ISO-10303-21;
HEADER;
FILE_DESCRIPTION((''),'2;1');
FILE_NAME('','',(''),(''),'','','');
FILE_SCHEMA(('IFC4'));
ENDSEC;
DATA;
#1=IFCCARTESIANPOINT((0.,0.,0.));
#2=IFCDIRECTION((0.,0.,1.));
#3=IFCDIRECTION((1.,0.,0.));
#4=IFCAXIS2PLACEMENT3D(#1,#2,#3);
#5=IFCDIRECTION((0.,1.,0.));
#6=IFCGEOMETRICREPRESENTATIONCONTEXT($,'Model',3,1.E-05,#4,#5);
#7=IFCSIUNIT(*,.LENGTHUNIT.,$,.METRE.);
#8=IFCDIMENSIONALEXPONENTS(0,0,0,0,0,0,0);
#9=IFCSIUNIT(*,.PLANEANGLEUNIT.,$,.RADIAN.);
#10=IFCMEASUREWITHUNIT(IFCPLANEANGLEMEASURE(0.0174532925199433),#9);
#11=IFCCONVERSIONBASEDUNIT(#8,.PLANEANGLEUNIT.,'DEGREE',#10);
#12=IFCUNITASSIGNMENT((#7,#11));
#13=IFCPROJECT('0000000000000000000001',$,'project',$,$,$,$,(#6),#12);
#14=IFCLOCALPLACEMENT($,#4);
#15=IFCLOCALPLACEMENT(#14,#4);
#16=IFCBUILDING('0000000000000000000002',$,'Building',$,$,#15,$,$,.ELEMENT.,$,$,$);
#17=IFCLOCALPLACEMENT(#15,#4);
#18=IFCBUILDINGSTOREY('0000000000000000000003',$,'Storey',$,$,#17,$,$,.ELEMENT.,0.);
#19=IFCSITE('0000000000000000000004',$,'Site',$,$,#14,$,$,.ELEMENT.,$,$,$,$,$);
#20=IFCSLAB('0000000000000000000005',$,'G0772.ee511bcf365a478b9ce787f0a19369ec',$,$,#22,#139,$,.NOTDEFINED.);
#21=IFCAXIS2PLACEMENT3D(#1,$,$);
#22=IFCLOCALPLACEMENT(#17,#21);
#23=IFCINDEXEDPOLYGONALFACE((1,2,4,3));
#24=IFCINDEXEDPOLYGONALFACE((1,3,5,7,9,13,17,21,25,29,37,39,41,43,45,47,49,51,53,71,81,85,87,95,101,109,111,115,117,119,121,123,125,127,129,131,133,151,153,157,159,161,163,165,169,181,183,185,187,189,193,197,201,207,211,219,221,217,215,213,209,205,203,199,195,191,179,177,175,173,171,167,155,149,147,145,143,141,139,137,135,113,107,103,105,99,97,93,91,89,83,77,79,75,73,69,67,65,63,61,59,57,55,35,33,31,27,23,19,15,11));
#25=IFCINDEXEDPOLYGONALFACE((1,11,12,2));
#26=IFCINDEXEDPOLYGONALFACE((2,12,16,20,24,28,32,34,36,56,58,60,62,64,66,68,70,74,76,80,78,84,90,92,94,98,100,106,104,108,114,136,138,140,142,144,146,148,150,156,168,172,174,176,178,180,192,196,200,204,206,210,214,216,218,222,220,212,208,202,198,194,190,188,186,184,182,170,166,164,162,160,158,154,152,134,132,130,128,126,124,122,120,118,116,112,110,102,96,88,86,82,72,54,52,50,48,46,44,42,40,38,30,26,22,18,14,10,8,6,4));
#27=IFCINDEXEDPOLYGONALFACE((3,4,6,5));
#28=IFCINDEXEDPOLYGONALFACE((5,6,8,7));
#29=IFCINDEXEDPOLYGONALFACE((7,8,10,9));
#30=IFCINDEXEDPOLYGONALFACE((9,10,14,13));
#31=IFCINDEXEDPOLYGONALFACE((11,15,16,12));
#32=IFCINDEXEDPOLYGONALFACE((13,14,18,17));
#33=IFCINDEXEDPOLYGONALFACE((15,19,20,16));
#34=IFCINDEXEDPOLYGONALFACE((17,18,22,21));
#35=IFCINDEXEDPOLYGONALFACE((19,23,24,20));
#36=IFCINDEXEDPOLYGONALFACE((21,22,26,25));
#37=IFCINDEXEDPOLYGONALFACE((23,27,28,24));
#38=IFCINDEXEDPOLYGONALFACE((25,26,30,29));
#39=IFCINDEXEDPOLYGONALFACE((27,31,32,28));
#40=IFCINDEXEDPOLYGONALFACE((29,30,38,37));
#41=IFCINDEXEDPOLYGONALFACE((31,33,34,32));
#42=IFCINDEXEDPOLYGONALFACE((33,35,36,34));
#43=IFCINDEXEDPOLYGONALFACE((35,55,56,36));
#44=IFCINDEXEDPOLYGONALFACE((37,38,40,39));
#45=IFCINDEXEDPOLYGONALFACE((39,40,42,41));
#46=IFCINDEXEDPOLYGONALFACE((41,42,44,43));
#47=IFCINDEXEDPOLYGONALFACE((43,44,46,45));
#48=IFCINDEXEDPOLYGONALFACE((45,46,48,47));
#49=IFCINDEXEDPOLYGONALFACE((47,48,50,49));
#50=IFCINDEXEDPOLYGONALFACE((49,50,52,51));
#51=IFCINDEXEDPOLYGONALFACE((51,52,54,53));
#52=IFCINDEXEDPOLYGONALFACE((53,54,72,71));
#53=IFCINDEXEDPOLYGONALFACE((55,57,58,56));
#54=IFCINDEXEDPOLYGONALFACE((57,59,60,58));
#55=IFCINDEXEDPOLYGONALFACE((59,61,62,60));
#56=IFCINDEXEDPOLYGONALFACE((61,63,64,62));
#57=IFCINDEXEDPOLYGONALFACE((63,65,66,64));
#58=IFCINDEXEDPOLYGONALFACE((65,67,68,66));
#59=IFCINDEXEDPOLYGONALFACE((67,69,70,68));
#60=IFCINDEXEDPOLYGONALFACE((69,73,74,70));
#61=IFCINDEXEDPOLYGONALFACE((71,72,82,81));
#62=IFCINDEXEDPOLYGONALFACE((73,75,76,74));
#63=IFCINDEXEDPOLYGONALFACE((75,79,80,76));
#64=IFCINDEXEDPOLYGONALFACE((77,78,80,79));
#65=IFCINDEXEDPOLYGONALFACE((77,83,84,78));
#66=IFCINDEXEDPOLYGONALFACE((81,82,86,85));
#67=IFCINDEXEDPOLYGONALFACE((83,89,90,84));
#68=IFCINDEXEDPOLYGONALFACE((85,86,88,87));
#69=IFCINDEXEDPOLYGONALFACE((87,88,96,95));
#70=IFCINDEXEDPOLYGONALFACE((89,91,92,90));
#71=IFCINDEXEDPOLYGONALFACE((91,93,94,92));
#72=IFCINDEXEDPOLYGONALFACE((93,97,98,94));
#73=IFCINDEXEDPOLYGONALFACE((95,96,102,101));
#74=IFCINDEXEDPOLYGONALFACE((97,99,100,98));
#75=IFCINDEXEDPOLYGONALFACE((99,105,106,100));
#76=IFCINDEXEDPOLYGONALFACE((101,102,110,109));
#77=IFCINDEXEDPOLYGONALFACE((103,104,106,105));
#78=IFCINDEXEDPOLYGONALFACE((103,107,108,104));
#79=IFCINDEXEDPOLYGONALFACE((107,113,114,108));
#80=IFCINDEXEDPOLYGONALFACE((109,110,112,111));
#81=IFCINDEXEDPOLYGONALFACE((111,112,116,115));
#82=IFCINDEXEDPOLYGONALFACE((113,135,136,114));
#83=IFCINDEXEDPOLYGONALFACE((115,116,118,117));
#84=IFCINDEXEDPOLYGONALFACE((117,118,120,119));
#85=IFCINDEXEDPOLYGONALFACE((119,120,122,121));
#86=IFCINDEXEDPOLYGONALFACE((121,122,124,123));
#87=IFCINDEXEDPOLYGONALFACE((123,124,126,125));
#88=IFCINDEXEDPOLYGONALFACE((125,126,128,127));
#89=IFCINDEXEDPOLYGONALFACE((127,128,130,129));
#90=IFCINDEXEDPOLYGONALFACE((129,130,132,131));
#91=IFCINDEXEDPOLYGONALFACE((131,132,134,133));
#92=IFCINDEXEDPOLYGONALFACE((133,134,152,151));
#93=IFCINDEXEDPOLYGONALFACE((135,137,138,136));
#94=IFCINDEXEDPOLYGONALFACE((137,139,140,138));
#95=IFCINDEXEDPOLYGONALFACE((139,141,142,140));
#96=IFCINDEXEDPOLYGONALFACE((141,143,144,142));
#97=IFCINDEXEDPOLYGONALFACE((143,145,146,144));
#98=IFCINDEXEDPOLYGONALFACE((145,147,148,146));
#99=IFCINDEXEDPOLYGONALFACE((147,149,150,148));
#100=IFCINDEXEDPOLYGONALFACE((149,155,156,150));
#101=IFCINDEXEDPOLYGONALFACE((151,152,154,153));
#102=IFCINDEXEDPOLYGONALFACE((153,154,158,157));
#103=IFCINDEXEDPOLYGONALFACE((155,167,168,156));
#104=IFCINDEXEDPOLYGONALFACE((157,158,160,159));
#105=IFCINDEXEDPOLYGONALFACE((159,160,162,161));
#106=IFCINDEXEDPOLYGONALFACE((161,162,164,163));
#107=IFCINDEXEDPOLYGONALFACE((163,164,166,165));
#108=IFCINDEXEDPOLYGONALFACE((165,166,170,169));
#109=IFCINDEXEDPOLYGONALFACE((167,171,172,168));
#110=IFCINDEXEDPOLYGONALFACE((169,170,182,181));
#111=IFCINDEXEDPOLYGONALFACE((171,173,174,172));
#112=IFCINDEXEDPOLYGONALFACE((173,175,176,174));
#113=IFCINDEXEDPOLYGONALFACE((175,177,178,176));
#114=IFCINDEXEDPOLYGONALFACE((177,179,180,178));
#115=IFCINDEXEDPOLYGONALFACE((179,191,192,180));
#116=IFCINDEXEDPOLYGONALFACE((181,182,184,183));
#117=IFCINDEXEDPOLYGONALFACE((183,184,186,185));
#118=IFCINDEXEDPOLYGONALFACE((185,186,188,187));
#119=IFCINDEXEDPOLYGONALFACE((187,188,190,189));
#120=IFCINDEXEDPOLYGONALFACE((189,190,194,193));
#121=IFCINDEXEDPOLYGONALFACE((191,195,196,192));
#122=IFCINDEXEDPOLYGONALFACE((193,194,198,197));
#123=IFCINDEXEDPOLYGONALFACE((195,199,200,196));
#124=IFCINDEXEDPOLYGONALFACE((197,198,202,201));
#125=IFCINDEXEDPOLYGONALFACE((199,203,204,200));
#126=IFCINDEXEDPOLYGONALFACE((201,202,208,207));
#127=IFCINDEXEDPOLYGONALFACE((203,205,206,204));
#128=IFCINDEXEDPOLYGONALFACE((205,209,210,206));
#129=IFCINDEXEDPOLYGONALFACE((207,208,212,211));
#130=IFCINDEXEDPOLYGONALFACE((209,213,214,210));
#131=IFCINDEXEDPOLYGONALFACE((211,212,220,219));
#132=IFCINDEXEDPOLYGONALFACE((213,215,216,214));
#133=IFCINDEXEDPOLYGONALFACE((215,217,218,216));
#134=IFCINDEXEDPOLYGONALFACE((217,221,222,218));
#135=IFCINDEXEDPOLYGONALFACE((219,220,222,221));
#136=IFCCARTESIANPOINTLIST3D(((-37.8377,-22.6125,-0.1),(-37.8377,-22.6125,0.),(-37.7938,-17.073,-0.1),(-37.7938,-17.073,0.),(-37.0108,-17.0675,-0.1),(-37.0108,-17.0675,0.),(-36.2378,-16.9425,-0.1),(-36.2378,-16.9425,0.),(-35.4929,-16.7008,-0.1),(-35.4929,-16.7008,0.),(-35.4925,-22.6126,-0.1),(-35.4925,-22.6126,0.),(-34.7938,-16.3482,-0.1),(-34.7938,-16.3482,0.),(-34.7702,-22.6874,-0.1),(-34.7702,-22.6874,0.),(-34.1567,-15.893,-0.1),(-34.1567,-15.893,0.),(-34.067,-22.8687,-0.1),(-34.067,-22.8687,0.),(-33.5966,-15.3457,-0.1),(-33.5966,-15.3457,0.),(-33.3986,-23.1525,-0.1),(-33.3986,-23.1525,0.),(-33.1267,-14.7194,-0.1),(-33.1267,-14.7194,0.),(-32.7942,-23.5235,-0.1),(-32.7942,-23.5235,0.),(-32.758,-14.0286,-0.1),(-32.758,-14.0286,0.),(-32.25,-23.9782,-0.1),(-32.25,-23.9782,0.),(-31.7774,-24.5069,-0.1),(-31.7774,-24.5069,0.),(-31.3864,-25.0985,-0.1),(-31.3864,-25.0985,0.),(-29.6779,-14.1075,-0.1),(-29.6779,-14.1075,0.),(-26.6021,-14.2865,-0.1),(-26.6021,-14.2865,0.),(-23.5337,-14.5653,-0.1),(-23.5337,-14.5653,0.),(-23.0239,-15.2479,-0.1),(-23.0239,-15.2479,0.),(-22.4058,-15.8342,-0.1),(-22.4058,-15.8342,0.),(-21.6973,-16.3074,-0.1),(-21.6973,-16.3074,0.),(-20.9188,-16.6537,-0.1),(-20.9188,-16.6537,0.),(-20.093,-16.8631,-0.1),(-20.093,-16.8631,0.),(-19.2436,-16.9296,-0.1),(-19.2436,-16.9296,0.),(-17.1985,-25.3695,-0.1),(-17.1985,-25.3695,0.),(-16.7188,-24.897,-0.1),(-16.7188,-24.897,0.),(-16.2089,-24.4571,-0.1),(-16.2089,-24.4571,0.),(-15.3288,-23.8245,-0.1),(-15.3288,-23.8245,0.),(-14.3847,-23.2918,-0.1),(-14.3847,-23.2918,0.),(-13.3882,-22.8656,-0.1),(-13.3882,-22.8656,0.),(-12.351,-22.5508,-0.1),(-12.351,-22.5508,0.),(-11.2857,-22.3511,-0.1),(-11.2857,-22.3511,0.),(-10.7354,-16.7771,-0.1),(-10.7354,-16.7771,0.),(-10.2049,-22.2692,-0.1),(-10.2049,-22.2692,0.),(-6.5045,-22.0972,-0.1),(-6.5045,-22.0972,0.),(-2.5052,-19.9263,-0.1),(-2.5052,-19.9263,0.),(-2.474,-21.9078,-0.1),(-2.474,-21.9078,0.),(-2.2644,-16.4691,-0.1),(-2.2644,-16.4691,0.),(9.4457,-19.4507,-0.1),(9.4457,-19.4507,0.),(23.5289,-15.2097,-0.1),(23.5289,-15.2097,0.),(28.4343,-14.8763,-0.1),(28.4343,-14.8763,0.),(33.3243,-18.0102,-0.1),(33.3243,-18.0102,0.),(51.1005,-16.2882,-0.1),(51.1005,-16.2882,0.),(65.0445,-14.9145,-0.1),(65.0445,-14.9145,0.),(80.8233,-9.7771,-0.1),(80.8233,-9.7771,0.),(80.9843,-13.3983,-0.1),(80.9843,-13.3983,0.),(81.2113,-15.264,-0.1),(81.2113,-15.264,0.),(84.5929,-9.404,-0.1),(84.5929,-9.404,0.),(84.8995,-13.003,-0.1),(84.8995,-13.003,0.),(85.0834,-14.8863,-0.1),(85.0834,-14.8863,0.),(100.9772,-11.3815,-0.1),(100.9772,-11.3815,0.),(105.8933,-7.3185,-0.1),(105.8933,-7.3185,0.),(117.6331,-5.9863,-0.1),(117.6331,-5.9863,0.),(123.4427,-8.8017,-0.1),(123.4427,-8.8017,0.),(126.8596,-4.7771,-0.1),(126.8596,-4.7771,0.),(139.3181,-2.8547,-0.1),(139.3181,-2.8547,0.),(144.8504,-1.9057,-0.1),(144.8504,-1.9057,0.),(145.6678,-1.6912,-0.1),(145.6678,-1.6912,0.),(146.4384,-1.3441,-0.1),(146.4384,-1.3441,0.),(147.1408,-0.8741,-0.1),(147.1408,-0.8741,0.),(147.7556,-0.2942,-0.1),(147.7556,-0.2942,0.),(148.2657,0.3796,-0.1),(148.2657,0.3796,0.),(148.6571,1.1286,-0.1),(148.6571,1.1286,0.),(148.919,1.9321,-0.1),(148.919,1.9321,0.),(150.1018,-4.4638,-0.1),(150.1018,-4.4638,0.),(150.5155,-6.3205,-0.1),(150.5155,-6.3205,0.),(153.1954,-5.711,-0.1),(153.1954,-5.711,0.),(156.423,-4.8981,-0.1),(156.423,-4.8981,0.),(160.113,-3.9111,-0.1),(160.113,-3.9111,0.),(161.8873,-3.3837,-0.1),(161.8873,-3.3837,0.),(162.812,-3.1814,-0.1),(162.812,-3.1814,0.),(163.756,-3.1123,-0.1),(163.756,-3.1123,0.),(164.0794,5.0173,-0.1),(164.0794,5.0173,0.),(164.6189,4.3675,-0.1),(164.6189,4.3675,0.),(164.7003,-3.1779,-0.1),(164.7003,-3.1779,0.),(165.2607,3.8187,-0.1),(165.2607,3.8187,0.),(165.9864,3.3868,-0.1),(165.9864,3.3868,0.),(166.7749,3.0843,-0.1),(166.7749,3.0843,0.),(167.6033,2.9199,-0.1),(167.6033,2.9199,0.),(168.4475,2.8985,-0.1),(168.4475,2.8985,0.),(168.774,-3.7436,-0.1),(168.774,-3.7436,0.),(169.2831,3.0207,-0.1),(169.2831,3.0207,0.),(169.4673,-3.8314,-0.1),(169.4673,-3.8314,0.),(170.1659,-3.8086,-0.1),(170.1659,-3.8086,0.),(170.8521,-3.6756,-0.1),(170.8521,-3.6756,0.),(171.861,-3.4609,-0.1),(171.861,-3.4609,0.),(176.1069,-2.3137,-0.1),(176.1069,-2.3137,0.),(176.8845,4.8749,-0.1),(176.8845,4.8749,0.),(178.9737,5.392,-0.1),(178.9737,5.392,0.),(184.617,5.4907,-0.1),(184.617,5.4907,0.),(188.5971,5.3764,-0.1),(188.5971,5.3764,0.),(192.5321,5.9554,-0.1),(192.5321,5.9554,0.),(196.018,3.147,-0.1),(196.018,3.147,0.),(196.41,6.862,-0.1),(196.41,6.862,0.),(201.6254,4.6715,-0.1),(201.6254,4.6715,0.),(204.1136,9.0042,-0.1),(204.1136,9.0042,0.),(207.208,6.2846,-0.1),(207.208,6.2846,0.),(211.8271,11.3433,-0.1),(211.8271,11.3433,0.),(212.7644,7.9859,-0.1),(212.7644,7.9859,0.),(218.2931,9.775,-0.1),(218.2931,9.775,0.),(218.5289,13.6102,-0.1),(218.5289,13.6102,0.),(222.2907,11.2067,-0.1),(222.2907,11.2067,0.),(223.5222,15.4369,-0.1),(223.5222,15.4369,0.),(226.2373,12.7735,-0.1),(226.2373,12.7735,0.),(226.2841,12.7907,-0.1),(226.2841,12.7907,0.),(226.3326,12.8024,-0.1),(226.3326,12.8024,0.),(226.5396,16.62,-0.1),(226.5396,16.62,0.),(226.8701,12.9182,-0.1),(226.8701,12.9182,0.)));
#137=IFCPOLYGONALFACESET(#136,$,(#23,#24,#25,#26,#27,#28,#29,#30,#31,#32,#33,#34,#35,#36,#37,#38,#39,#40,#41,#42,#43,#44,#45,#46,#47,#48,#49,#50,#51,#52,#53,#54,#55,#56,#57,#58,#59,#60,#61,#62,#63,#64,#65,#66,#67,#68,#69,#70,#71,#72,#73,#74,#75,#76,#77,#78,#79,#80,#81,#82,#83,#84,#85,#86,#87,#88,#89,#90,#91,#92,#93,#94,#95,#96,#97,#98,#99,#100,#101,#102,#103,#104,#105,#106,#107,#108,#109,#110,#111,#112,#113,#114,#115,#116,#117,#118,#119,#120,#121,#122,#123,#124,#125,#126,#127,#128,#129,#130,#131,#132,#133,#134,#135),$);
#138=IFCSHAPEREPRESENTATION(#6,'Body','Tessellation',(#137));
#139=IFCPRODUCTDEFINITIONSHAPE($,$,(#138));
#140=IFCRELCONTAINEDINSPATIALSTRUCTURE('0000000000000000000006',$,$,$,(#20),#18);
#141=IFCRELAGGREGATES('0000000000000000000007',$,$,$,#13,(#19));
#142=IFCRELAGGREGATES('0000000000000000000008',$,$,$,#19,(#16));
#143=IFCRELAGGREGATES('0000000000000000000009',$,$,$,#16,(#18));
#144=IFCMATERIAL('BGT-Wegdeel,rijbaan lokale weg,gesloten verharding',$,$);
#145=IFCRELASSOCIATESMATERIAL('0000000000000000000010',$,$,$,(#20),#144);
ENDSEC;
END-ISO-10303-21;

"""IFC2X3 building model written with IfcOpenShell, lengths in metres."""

from ifc_helpers import new_model, entity, si_unit, converted_unit, direction, frame, origin_with_axes, place, context, project, spatial, polyline, outline, extrude, material, element, save


model = new_model("IFC2X3")

# Units and contexts
model_context = context("Model", 3, precision=1e-05, world=origin_with_axes(), true_north=direction((0.0, 1.0, 0.0)))
ifc_project = project(units=[si_unit("LENGTHUNIT", "METRE"), converted_unit("PLANEANGLEUNIT", "DEGREE", entity("IfcPlaneAngleMeasure", 0.0174532925199433), si_unit("PLANEANGLEUNIT", "RADIAN"), dimensions=[0, 0, 0, 0, 0, 0, 0])], contexts=[model_context])

# Site, building, storey
site_placement = place(None, origin_with_axes())
site = spatial("IfcSite", under=ifc_project, at=site_placement, Name="Site", CompositionType="ELEMENT")
building_placement = place(site_placement, origin_with_axes())
building = spatial("IfcBuilding", under=site, at=building_placement, Name="Building", CompositionType="ELEMENT")
storey_placement = place(building_placement, origin_with_axes())
storey = spatial("IfcBuildingStorey", under=building, at=storey_placement, Name="Storey", CompositionType="ELEMENT", Elevation=0.0)

# Slab
ifc_material_1 = material(Name="BGT-Wegdeel,rijbaan lokale weg,gesloten verharding")
slab_1_placement = place(storey_placement, frame((0.0, 0.0, -0.1), z_axis=(0.0, 0.0, 1.0), x_axis=(1.0, 0.0, 0.0)))
element("IfcSlab", 1, at=slab_1_placement, inside=storey, material=ifc_material_1, Name="G0772.ee511bcf365a478b9ce787f0a19369ec", PredefinedType="NOTDEFINED", context=model_context, shape_type="SweptSolid", body=[
    extrude(outline(polyline([(80.8233, -9.7771), (84.5929, -9.404), (105.8933, -7.3185), (117.6331, -5.9863), (126.8596, -4.7771), (139.3181, -2.8547), (144.8504, -1.9057), (145.6678, -1.6912), (146.4384, -1.3441), (147.1408, -0.8741), (147.7556, -0.2942), (148.2657, 0.3796), (148.6571, 1.1286), (148.919, 1.9321), (164.0794, 5.0173), (164.6189, 4.3675), (165.2607, 3.8187), (165.9864, 3.3868), (166.7749, 3.0843), (167.6033, 2.9199), (168.4475, 2.8985), (169.2831, 3.0207), (176.8845, 4.8749), (178.9737, 5.392), (184.617, 5.4907), (188.5971, 5.3764), (192.5321, 5.9554), (196.41, 6.862), (204.1136, 9.0042), (211.8271, 11.3433), (218.5289, 13.6102), (223.5222, 15.4369), (226.5396, 16.62), (226.8701, 12.9182), (226.3326, 12.8024), (226.2841, 12.7907), (226.2373, 12.7735), (222.2907, 11.2067), (218.2931, 9.775), (212.7644, 7.9859), (207.208, 6.2846), (201.6254, 4.6715), (196.018, 3.147), (176.1069, -2.3137), (171.861, -3.4609), (170.8521, -3.6756), (170.1659, -3.8086), (169.4673, -3.8314), (168.774, -3.7436), (164.7003, -3.1779), (163.756, -3.1123), (162.812, -3.1814), (161.8873, -3.3837), (160.113, -3.9111), (156.423, -4.8981), (153.1954, -5.711), (150.5155, -6.3205), (150.1018, -4.4638), (123.4427, -8.8017), (100.9772, -11.3815), (84.8995, -13.003), (85.0834, -14.8863), (81.2113, -15.264), (80.9843, -13.3983), (65.0445, -14.9145), (51.1005, -16.2882), (33.3243, -18.0102), (9.4457, -19.4507), (-2.5052, -19.9263), (-2.474, -21.9078), (-6.5045, -22.0972), (-10.2049, -22.2692), (-11.2857, -22.3511), (-12.351, -22.5508), (-13.3882, -22.8656), (-14.3847, -23.2918), (-15.3288, -23.8245), (-16.2089, -24.4571), (-16.7188, -24.897), (-17.1985, -25.3695), (-31.3864, -25.0985), (-31.7774, -24.5069), (-32.25, -23.9782), (-32.7942, -23.5235), (-33.3986, -23.1525), (-34.067, -22.8687), (-34.7702, -22.6874), (-35.4925, -22.6126), (-37.8377, -22.6125), (-37.7938, -17.073), (-37.0108, -17.0675), (-36.2378, -16.9425), (-35.4929, -16.7008), (-34.7938, -16.3482), (-34.1567, -15.893), (-33.5966, -15.3457), (-33.1267, -14.7194), (-32.758, -14.0286), (-29.6779, -14.1075), (-26.6021, -14.2865), (-23.5337, -14.5653), (-23.0239, -15.2479), (-22.4058, -15.8342), (-21.6973, -16.3074), (-20.9188, -16.6537), (-20.093, -16.8631), (-19.2436, -16.9296), (-10.7354, -16.7771), (-2.2644, -16.4691), (23.5289, -15.2097), (28.4343, -14.8763), (80.8233, -9.7771)])), origin_with_axes(), (0.0, 0.0, 1.0), 0.1),
])

save(model, "model.ifc")
